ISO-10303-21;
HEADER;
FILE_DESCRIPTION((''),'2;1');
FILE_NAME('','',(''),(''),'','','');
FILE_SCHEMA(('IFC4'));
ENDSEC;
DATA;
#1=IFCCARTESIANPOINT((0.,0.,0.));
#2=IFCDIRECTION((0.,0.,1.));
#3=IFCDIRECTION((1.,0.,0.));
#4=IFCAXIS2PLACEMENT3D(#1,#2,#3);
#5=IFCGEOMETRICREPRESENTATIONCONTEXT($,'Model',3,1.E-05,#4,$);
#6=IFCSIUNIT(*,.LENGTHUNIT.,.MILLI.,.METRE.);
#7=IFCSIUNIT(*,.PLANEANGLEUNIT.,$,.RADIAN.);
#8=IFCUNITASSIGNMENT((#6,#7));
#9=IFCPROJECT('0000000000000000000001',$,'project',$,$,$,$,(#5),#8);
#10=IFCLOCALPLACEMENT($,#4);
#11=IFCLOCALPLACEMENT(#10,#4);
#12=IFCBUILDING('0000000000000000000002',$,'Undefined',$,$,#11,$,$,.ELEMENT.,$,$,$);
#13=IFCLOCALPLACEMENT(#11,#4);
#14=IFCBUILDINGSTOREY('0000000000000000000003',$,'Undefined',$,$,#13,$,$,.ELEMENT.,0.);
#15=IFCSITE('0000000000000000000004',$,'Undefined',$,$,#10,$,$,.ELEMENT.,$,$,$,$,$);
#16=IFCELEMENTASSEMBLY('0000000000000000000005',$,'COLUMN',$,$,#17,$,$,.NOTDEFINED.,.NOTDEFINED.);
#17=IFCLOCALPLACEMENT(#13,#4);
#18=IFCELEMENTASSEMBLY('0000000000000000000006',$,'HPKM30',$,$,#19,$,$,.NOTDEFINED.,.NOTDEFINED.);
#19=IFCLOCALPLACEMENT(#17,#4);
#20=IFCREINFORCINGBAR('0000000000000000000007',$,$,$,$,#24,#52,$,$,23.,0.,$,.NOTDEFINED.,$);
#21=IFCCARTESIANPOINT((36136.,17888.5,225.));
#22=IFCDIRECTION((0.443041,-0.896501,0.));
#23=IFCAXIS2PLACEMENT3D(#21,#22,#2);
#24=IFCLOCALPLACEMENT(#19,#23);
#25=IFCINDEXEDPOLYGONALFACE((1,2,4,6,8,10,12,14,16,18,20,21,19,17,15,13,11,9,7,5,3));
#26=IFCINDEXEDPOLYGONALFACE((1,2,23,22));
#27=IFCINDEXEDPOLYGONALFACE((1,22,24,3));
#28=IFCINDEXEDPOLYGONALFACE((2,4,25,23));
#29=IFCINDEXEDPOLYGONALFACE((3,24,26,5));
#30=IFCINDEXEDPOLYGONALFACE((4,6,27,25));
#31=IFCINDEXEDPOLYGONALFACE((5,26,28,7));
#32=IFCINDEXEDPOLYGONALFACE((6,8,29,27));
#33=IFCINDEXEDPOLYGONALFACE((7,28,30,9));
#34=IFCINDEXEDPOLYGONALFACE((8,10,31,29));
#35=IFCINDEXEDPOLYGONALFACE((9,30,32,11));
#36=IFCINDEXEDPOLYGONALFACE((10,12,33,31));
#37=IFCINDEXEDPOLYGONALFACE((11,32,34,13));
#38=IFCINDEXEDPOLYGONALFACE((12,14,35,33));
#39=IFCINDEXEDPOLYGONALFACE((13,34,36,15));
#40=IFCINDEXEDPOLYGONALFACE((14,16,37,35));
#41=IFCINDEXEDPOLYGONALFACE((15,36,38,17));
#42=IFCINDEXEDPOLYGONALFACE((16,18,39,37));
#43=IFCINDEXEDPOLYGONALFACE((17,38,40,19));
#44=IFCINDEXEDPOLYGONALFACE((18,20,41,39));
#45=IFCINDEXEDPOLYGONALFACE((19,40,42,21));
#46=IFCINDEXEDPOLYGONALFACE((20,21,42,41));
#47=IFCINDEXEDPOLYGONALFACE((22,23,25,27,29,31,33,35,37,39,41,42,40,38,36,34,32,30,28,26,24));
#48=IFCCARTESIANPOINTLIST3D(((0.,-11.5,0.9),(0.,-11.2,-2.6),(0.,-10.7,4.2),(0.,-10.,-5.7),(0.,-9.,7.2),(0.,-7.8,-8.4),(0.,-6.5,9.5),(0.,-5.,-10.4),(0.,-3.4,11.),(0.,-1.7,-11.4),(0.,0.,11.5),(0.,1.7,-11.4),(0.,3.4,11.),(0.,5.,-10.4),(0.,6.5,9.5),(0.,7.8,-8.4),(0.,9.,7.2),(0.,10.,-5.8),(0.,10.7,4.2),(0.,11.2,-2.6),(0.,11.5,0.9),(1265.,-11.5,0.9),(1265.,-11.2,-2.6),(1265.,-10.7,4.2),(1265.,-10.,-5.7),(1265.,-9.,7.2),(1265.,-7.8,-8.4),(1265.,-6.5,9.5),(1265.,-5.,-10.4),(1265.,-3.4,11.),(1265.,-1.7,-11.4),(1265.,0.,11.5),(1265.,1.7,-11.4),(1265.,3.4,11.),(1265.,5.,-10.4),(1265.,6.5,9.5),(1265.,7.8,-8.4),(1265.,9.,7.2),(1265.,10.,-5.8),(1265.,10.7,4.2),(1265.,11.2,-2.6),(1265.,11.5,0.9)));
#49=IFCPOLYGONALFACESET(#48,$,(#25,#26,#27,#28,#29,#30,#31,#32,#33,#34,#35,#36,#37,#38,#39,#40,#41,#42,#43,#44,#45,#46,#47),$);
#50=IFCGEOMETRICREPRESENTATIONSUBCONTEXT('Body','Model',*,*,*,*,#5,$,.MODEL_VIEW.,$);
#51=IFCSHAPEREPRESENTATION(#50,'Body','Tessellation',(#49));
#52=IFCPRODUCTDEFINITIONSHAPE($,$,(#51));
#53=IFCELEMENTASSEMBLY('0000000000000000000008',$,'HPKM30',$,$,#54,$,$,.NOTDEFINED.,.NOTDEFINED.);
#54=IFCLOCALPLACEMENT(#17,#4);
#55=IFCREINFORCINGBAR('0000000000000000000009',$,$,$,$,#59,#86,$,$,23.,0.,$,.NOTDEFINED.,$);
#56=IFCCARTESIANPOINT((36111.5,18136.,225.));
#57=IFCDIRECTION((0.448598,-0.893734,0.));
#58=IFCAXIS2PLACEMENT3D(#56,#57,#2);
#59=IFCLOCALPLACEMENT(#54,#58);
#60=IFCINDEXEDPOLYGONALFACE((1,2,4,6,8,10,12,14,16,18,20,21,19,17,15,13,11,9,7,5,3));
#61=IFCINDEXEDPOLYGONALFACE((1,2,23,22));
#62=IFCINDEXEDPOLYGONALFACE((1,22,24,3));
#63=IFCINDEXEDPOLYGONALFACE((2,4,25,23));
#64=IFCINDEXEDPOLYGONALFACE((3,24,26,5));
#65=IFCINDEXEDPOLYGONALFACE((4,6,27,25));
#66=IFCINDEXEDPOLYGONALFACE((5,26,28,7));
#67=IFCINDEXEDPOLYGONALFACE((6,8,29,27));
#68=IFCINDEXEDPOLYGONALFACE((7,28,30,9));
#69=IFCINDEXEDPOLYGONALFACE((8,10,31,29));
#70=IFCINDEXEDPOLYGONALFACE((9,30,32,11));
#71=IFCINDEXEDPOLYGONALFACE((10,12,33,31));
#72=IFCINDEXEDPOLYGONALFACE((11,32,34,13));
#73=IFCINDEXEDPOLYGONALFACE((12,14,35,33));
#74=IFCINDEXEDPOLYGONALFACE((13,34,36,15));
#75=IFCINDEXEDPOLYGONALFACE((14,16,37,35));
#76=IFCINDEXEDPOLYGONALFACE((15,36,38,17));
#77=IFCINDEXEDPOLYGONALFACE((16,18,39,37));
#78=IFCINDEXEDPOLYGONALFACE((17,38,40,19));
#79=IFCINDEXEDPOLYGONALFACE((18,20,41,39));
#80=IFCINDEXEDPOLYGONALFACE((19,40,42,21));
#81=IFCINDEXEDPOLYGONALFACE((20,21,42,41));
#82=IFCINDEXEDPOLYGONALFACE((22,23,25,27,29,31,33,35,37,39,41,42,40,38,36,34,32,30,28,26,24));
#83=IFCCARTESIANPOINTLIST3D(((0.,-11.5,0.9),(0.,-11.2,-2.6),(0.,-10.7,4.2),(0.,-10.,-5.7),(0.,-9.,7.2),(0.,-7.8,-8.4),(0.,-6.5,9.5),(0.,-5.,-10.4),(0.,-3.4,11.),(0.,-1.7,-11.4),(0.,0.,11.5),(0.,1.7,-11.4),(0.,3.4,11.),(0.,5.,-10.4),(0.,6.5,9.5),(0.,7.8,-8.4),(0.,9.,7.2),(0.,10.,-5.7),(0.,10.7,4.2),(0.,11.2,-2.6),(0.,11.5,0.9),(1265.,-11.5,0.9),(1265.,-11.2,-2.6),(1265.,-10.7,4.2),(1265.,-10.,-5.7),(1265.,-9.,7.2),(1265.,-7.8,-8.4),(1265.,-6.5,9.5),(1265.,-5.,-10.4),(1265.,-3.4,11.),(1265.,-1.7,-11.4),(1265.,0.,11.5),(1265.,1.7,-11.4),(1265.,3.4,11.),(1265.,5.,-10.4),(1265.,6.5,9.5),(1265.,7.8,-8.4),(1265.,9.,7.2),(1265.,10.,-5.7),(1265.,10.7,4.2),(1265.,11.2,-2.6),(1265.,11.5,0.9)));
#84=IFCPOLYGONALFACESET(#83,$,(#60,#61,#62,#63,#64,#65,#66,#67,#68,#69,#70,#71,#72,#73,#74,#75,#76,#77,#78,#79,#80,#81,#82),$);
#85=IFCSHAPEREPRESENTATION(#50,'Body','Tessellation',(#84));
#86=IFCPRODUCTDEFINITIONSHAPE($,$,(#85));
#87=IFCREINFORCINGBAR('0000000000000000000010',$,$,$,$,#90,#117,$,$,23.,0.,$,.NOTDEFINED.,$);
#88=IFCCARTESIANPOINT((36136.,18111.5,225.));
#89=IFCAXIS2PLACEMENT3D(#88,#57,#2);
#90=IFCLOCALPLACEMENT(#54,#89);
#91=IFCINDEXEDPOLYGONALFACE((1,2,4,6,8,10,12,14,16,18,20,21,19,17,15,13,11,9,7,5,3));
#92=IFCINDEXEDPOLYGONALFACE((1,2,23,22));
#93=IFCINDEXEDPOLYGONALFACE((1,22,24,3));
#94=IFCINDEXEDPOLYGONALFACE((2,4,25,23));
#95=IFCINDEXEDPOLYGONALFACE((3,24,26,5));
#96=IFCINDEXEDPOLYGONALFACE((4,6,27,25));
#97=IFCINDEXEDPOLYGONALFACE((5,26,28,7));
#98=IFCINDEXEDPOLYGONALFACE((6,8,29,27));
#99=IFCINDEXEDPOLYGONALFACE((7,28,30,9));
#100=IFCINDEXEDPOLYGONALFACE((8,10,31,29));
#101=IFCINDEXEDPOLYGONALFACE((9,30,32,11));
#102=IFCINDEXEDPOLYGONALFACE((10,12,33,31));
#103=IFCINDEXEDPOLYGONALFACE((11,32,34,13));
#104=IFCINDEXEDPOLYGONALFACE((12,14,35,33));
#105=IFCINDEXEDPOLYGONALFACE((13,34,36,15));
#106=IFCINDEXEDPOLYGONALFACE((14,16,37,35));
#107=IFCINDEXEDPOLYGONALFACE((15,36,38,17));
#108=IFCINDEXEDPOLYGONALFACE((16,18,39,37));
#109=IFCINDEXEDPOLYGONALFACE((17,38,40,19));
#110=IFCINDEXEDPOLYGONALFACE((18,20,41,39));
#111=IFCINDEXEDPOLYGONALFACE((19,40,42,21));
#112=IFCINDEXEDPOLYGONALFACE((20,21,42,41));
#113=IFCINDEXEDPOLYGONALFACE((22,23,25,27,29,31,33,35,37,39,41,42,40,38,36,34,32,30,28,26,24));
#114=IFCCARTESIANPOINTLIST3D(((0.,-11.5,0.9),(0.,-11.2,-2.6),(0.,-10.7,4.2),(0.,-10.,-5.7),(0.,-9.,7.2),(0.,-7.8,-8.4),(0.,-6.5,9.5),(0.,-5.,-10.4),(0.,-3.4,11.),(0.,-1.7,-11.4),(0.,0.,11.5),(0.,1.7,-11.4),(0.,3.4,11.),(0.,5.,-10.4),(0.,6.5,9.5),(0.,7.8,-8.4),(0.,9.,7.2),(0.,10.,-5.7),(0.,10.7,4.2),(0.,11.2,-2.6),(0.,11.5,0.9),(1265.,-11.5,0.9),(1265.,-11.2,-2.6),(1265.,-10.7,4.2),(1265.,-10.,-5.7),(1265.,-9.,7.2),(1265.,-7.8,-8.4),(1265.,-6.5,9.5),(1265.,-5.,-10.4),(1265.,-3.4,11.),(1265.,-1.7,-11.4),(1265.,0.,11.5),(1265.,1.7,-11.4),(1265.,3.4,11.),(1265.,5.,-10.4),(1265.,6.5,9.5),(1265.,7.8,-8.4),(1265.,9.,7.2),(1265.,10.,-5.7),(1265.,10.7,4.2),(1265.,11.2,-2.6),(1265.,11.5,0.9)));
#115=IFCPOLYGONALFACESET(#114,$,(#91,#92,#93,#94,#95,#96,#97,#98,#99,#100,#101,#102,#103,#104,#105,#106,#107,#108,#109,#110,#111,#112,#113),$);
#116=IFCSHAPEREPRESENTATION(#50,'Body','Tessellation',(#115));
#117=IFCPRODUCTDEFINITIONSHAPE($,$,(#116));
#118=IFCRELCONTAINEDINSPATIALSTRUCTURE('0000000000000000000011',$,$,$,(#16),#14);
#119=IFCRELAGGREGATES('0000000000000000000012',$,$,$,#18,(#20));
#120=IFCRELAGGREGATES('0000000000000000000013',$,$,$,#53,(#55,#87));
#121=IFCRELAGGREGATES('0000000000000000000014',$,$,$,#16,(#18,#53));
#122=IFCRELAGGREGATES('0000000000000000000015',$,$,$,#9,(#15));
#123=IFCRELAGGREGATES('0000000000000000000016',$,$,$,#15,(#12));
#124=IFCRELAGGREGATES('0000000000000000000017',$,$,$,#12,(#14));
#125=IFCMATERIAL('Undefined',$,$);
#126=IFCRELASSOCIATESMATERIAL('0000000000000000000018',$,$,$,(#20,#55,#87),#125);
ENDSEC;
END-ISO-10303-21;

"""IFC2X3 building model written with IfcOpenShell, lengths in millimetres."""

from ifc_helpers import new_model, entity, si_unit, frame, origin_with_axes, place, context, subcontext, project, spatial, source, transform, mapped, material, element, aggregate, save


model = new_model("IFC2X3")

# Units and contexts
model_context = context("Model", 3, precision=1e-05, world=origin_with_axes())
body_context = subcontext(model_context, "Body", "Model", "MODEL_VIEW")
ifc_project = project(units=[si_unit("LENGTHUNIT", "METRE", prefix="MILLI"), si_unit("PLANEANGLEUNIT", "RADIAN")], contexts=[model_context])

# Site, building, storey
site_placement = place(None, origin_with_axes())
site = spatial("IfcSite", under=ifc_project, at=site_placement, Name="Undefined", CompositionType="ELEMENT")
building_placement = place(site_placement, origin_with_axes())
building = spatial("IfcBuilding", under=site, at=building_placement, Name="Undefined", CompositionType="ELEMENT")
storey_placement = place(building_placement, origin_with_axes())
storey = spatial("IfcBuildingStorey", under=building, at=storey_placement, Name="Undefined", CompositionType="ELEMENT", Elevation=0.0)

# Element assembly
assembly_1_placement = place(storey_placement, origin_with_axes())
assembly_1 = element("IfcElementAssembly", 1, at=assembly_1_placement, inside=storey, Name="COLUMN", AssemblyPlace="NOTDEFINED", PredefinedType="NOTDEFINED")

# Shared definitions
ifc_material_1 = material(Name="Undefined")

# Element assembly, reinforcing bar
assembly_2_placement = place(assembly_1_placement, origin_with_axes())
assembly_2 = element("IfcElementAssembly", 2, at=assembly_2_placement, Name="HPKM30", AssemblyPlace="NOTDEFINED", PredefinedType="NOTDEFINED")
shared_shape_1 = source(origin_with_axes(), body_context, "Body", "AdvancedSweptSolid", [
    entity("IfcSweptDiskSolid", entity("IfcTrimmedCurve", entity("IfcLine", entity("IfcCartesianPoint", [0.0, 0.0, 0.0]), entity("IfcVector", entity("IfcDirection", [1.0, 0.0, 0.0]), 1.0)), [entity("IfcParameterValue", 0.0)], [entity("IfcParameterValue", 1265.0)], True, "PARAMETER"), 11.5, None, 0.0, 1265.0),
])
reinforcing_bar_1_placement = place(assembly_2_placement, frame((36136.0, 17888.5, 225.0), z_axis=(0.443041, -0.896501, 0.0), x_axis=(0.0, 0.0, 1.0)))
reinforcing_bar_1 = element("IfcReinforcingBar", 3, at=reinforcing_bar_1_placement, material=ifc_material_1, BarRole="NOTDEFINED", CrossSectionArea=0.0, NominalDiameter=23.0, context=body_context, shape_type="MappedRepresentation", body=[
    mapped(shared_shape_1, transform((0.0, 0.0, 0.0))),
])
aggregate(assembly_2, [reinforcing_bar_1])

# Element assembly, reinforcing bars
assembly_3_placement = place(assembly_1_placement, origin_with_axes())
assembly_3 = element("IfcElementAssembly", 4, at=assembly_3_placement, Name="HPKM30", AssemblyPlace="NOTDEFINED", PredefinedType="NOTDEFINED")
shared_shape_2 = source(origin_with_axes(), body_context, "Body", "AdvancedSweptSolid", [
    entity("IfcSweptDiskSolid", entity("IfcTrimmedCurve", entity("IfcLine", entity("IfcCartesianPoint", [0.0, 0.0, 0.0]), entity("IfcVector", entity("IfcDirection", [1.0, 0.0, 0.0]), 1.0)), [entity("IfcParameterValue", 0.0)], [entity("IfcParameterValue", 1265.0)], True, "PARAMETER"), 11.5, None, 0.0, 1265.0),
])
reinforcing_bar_2_placement = place(assembly_3_placement, frame((36111.5, 18136.0, 225.0), z_axis=(0.448598, -0.893734, 0.0), x_axis=(0.0, 0.0, 1.0)))
reinforcing_bar_2 = element("IfcReinforcingBar", 5, at=reinforcing_bar_2_placement, material=ifc_material_1, BarRole="NOTDEFINED", CrossSectionArea=0.0, NominalDiameter=23.0, context=body_context, shape_type="MappedRepresentation", body=[
    mapped(shared_shape_2, transform((0.0, 0.0, 0.0))),
])
shared_shape_3 = source(origin_with_axes(), body_context, "Body", "AdvancedSweptSolid", [
    entity("IfcSweptDiskSolid", entity("IfcTrimmedCurve", entity("IfcLine", entity("IfcCartesianPoint", [0.0, 0.0, 0.0]), entity("IfcVector", entity("IfcDirection", [1.0, 0.0, 0.0]), 1.0)), [entity("IfcParameterValue", 0.0)], [entity("IfcParameterValue", 1265.0)], True, "PARAMETER"), 11.5, None, 0.0, 1265.0),
])
reinforcing_bar_3_placement = place(assembly_3_placement, frame((36136.0, 18111.5, 225.0), z_axis=(0.448598, -0.893734, 0.0), x_axis=(0.0, 0.0, 1.0)))
reinforcing_bar_3 = element("IfcReinforcingBar", 6, at=reinforcing_bar_3_placement, material=ifc_material_1, BarRole="NOTDEFINED", CrossSectionArea=0.0, NominalDiameter=23.0, context=body_context, shape_type="MappedRepresentation", body=[
    mapped(shared_shape_3, transform((0.0, 0.0, 0.0))),
])
aggregate(assembly_3, [reinforcing_bar_2, reinforcing_bar_3])

aggregate(assembly_1, [assembly_2, assembly_3])

save(model, "model.ifc")
